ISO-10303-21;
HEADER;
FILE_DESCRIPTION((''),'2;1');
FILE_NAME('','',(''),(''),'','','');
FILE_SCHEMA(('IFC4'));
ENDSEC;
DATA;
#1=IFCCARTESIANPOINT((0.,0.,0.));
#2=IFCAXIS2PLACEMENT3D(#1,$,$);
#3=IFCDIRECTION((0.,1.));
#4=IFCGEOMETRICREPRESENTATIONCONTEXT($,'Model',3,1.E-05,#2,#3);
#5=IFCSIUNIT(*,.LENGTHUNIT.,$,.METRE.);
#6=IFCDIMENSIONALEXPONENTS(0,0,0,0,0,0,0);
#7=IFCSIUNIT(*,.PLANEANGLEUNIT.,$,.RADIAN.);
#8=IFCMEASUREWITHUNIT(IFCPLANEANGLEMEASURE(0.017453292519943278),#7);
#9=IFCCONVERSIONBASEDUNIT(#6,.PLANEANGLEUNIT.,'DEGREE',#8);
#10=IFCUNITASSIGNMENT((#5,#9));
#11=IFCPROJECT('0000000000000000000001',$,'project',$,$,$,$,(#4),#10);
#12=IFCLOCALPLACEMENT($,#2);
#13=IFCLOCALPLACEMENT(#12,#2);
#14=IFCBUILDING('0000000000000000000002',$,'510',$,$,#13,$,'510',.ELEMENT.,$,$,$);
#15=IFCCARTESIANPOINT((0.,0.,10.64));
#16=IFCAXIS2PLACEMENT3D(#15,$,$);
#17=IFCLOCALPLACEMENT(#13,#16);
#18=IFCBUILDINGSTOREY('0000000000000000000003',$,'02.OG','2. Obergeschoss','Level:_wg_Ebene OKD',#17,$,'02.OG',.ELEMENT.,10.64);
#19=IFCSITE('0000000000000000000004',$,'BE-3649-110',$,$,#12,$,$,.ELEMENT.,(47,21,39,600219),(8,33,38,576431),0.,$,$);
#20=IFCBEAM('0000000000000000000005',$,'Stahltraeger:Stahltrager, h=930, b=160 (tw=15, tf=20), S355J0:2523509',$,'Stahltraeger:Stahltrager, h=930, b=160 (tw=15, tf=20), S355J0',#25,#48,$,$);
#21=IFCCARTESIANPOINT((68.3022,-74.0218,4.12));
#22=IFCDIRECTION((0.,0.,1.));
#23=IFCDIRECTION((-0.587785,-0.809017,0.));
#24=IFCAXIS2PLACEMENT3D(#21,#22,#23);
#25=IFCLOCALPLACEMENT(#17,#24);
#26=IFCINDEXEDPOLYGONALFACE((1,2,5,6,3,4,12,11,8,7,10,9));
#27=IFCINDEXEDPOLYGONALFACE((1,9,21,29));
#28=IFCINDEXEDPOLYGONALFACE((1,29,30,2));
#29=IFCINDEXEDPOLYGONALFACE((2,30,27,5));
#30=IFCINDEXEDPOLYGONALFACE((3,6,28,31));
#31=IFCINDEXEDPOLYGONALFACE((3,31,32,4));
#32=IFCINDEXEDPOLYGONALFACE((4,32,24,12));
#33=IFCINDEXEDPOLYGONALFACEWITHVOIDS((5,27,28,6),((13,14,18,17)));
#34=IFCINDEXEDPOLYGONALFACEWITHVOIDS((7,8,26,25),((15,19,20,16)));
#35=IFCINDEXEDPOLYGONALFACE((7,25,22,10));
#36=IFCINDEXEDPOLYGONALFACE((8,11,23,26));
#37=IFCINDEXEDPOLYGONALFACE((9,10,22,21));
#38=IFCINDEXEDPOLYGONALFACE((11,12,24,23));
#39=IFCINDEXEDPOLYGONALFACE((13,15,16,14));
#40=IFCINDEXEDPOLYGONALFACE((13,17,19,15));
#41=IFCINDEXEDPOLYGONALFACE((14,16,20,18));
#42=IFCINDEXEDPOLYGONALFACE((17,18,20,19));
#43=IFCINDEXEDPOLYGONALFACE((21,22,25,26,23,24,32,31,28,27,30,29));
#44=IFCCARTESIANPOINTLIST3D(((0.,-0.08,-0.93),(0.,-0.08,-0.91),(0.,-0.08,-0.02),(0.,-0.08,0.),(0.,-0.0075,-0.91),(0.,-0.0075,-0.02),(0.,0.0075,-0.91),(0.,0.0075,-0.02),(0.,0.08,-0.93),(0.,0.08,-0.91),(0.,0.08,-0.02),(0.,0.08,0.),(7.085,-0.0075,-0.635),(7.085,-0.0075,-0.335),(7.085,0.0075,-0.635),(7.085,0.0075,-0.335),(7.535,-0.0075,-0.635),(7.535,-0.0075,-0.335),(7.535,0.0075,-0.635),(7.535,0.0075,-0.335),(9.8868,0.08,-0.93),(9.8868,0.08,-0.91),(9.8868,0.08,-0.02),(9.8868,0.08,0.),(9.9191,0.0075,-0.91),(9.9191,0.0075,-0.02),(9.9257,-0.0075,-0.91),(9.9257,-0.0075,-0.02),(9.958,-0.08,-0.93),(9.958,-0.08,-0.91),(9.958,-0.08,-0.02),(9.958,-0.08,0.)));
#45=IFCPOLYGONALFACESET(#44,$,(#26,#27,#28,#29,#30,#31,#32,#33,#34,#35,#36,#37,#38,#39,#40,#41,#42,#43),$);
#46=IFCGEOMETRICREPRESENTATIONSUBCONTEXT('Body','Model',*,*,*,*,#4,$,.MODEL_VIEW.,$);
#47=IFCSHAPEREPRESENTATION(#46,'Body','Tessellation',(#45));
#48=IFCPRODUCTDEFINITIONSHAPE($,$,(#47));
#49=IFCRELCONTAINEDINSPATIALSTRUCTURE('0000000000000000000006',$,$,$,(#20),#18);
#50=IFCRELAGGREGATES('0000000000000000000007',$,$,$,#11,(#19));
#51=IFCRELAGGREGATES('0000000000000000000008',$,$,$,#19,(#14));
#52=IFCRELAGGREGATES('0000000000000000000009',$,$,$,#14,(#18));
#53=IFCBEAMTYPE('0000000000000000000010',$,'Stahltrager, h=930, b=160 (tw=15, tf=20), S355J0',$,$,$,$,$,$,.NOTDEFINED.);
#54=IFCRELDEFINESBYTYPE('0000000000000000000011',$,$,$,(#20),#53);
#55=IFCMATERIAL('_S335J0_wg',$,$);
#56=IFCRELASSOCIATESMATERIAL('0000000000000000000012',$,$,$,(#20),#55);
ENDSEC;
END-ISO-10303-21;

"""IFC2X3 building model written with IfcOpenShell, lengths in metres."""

from ifc_helpers import new_model, entity, si_unit, converted_unit, direction, frame, frame_2d, origin, place, context, subcontext, project, spatial, rectangle, i_section, extrude, boolean, clip, halfspace, material, type_object, element, save


model = new_model("IFC2X3")

# Units and contexts
model_context = context("Model", 3, precision=1e-05, world=origin(), true_north=direction((0.0, 1.0)))
body_context = subcontext(model_context, "Body", "Model", "MODEL_VIEW")
ifc_project = project(units=[si_unit("LENGTHUNIT", "METRE"), converted_unit("PLANEANGLEUNIT", "DEGREE", entity("IfcPlaneAngleMeasure", 0.017453292519943278), si_unit("PLANEANGLEUNIT", "RADIAN"), dimensions=[0, 0, 0, 0, 0, 0, 0])], contexts=[model_context])

# Site, building, storey
site_placement = place(None, origin())
site = spatial("IfcSite", under=ifc_project, at=site_placement, Name="BE-3649-110", CompositionType="ELEMENT", RefLatitude=(47, 21, 39, 600219), RefLongitude=(8, 33, 38, 576431), RefElevation=0.0)
building_placement = place(site_placement, origin())
building = spatial("IfcBuilding", under=site, at=building_placement, Name="510", LongName="510", CompositionType="ELEMENT")
storey_placement = place(building_placement, frame((0.0, 0.0, 10.64)))
storey = spatial("IfcBuildingStorey", under=building, at=storey_placement, Name="02.OG", Description="2. Obergeschoss", ObjectType="Level:_wg_Ebene OKD", LongName="02.OG", CompositionType="ELEMENT", Elevation=10.64)

# Beam
ifc_material_1 = material(Name="_S335J0_wg")
beam_type_1 = type_object("IfcBeamType", Name="Stahltrager, h=930, b=160 (tw=15, tf=20), S355J0", PredefinedType="NOTDEFINED")
beam_1_placement = place(storey_placement, frame((68.3022, -74.0218, 4.12), z_axis=(0.0, 0.0, 1.0), x_axis=(-0.587785, -0.809017, 0.0)))
element("IfcBeam", 1, at=beam_1_placement, inside=storey, type_object=beam_type_1, material=ifc_material_1, Name="Stahltraeger:Stahltrager, h=930, b=160 (tw=15, tf=20), S355J0:2523509", ObjectType="Stahltraeger:Stahltrager, h=930, b=160 (tw=15, tf=20), S355J0", context=body_context, shape_type="SweptSolid", body=[
    boolean("DIFFERENCE", clip(extrude(i_section(OverallWidth=0.16, OverallDepth=0.93, WebThickness=0.015, FlangeThickness=0.02, at=frame_2d((0.0, 0.0), x_axis=(0.0, 1.0))), frame((0.0, 0.0, -0.465), z_axis=(1.0, 0.0, 0.0), x_axis=(0.0, 0.0, -1.0)), (0.0, 0.0, 1.0), 9.958), halfspace(frame((9.7654, 0.3527, 9.5578), z_axis=(0.913545, 0.406737, 0.0), x_axis=(0.0, 0.0, -1.0)), False)), extrude(rectangle(XDim=0.3, YDim=0.45, at=frame_2d((0.0, 0.0), x_axis=(0.0, 1.0))), frame((7.31, 0.0075, -0.485), z_axis=(0.0, -1.0, 0.0), x_axis=(-1.0, 0.0, 0.0)), (0.0, 0.0, 1.0), 0.015)),
])

save(model, "model.ifc")
